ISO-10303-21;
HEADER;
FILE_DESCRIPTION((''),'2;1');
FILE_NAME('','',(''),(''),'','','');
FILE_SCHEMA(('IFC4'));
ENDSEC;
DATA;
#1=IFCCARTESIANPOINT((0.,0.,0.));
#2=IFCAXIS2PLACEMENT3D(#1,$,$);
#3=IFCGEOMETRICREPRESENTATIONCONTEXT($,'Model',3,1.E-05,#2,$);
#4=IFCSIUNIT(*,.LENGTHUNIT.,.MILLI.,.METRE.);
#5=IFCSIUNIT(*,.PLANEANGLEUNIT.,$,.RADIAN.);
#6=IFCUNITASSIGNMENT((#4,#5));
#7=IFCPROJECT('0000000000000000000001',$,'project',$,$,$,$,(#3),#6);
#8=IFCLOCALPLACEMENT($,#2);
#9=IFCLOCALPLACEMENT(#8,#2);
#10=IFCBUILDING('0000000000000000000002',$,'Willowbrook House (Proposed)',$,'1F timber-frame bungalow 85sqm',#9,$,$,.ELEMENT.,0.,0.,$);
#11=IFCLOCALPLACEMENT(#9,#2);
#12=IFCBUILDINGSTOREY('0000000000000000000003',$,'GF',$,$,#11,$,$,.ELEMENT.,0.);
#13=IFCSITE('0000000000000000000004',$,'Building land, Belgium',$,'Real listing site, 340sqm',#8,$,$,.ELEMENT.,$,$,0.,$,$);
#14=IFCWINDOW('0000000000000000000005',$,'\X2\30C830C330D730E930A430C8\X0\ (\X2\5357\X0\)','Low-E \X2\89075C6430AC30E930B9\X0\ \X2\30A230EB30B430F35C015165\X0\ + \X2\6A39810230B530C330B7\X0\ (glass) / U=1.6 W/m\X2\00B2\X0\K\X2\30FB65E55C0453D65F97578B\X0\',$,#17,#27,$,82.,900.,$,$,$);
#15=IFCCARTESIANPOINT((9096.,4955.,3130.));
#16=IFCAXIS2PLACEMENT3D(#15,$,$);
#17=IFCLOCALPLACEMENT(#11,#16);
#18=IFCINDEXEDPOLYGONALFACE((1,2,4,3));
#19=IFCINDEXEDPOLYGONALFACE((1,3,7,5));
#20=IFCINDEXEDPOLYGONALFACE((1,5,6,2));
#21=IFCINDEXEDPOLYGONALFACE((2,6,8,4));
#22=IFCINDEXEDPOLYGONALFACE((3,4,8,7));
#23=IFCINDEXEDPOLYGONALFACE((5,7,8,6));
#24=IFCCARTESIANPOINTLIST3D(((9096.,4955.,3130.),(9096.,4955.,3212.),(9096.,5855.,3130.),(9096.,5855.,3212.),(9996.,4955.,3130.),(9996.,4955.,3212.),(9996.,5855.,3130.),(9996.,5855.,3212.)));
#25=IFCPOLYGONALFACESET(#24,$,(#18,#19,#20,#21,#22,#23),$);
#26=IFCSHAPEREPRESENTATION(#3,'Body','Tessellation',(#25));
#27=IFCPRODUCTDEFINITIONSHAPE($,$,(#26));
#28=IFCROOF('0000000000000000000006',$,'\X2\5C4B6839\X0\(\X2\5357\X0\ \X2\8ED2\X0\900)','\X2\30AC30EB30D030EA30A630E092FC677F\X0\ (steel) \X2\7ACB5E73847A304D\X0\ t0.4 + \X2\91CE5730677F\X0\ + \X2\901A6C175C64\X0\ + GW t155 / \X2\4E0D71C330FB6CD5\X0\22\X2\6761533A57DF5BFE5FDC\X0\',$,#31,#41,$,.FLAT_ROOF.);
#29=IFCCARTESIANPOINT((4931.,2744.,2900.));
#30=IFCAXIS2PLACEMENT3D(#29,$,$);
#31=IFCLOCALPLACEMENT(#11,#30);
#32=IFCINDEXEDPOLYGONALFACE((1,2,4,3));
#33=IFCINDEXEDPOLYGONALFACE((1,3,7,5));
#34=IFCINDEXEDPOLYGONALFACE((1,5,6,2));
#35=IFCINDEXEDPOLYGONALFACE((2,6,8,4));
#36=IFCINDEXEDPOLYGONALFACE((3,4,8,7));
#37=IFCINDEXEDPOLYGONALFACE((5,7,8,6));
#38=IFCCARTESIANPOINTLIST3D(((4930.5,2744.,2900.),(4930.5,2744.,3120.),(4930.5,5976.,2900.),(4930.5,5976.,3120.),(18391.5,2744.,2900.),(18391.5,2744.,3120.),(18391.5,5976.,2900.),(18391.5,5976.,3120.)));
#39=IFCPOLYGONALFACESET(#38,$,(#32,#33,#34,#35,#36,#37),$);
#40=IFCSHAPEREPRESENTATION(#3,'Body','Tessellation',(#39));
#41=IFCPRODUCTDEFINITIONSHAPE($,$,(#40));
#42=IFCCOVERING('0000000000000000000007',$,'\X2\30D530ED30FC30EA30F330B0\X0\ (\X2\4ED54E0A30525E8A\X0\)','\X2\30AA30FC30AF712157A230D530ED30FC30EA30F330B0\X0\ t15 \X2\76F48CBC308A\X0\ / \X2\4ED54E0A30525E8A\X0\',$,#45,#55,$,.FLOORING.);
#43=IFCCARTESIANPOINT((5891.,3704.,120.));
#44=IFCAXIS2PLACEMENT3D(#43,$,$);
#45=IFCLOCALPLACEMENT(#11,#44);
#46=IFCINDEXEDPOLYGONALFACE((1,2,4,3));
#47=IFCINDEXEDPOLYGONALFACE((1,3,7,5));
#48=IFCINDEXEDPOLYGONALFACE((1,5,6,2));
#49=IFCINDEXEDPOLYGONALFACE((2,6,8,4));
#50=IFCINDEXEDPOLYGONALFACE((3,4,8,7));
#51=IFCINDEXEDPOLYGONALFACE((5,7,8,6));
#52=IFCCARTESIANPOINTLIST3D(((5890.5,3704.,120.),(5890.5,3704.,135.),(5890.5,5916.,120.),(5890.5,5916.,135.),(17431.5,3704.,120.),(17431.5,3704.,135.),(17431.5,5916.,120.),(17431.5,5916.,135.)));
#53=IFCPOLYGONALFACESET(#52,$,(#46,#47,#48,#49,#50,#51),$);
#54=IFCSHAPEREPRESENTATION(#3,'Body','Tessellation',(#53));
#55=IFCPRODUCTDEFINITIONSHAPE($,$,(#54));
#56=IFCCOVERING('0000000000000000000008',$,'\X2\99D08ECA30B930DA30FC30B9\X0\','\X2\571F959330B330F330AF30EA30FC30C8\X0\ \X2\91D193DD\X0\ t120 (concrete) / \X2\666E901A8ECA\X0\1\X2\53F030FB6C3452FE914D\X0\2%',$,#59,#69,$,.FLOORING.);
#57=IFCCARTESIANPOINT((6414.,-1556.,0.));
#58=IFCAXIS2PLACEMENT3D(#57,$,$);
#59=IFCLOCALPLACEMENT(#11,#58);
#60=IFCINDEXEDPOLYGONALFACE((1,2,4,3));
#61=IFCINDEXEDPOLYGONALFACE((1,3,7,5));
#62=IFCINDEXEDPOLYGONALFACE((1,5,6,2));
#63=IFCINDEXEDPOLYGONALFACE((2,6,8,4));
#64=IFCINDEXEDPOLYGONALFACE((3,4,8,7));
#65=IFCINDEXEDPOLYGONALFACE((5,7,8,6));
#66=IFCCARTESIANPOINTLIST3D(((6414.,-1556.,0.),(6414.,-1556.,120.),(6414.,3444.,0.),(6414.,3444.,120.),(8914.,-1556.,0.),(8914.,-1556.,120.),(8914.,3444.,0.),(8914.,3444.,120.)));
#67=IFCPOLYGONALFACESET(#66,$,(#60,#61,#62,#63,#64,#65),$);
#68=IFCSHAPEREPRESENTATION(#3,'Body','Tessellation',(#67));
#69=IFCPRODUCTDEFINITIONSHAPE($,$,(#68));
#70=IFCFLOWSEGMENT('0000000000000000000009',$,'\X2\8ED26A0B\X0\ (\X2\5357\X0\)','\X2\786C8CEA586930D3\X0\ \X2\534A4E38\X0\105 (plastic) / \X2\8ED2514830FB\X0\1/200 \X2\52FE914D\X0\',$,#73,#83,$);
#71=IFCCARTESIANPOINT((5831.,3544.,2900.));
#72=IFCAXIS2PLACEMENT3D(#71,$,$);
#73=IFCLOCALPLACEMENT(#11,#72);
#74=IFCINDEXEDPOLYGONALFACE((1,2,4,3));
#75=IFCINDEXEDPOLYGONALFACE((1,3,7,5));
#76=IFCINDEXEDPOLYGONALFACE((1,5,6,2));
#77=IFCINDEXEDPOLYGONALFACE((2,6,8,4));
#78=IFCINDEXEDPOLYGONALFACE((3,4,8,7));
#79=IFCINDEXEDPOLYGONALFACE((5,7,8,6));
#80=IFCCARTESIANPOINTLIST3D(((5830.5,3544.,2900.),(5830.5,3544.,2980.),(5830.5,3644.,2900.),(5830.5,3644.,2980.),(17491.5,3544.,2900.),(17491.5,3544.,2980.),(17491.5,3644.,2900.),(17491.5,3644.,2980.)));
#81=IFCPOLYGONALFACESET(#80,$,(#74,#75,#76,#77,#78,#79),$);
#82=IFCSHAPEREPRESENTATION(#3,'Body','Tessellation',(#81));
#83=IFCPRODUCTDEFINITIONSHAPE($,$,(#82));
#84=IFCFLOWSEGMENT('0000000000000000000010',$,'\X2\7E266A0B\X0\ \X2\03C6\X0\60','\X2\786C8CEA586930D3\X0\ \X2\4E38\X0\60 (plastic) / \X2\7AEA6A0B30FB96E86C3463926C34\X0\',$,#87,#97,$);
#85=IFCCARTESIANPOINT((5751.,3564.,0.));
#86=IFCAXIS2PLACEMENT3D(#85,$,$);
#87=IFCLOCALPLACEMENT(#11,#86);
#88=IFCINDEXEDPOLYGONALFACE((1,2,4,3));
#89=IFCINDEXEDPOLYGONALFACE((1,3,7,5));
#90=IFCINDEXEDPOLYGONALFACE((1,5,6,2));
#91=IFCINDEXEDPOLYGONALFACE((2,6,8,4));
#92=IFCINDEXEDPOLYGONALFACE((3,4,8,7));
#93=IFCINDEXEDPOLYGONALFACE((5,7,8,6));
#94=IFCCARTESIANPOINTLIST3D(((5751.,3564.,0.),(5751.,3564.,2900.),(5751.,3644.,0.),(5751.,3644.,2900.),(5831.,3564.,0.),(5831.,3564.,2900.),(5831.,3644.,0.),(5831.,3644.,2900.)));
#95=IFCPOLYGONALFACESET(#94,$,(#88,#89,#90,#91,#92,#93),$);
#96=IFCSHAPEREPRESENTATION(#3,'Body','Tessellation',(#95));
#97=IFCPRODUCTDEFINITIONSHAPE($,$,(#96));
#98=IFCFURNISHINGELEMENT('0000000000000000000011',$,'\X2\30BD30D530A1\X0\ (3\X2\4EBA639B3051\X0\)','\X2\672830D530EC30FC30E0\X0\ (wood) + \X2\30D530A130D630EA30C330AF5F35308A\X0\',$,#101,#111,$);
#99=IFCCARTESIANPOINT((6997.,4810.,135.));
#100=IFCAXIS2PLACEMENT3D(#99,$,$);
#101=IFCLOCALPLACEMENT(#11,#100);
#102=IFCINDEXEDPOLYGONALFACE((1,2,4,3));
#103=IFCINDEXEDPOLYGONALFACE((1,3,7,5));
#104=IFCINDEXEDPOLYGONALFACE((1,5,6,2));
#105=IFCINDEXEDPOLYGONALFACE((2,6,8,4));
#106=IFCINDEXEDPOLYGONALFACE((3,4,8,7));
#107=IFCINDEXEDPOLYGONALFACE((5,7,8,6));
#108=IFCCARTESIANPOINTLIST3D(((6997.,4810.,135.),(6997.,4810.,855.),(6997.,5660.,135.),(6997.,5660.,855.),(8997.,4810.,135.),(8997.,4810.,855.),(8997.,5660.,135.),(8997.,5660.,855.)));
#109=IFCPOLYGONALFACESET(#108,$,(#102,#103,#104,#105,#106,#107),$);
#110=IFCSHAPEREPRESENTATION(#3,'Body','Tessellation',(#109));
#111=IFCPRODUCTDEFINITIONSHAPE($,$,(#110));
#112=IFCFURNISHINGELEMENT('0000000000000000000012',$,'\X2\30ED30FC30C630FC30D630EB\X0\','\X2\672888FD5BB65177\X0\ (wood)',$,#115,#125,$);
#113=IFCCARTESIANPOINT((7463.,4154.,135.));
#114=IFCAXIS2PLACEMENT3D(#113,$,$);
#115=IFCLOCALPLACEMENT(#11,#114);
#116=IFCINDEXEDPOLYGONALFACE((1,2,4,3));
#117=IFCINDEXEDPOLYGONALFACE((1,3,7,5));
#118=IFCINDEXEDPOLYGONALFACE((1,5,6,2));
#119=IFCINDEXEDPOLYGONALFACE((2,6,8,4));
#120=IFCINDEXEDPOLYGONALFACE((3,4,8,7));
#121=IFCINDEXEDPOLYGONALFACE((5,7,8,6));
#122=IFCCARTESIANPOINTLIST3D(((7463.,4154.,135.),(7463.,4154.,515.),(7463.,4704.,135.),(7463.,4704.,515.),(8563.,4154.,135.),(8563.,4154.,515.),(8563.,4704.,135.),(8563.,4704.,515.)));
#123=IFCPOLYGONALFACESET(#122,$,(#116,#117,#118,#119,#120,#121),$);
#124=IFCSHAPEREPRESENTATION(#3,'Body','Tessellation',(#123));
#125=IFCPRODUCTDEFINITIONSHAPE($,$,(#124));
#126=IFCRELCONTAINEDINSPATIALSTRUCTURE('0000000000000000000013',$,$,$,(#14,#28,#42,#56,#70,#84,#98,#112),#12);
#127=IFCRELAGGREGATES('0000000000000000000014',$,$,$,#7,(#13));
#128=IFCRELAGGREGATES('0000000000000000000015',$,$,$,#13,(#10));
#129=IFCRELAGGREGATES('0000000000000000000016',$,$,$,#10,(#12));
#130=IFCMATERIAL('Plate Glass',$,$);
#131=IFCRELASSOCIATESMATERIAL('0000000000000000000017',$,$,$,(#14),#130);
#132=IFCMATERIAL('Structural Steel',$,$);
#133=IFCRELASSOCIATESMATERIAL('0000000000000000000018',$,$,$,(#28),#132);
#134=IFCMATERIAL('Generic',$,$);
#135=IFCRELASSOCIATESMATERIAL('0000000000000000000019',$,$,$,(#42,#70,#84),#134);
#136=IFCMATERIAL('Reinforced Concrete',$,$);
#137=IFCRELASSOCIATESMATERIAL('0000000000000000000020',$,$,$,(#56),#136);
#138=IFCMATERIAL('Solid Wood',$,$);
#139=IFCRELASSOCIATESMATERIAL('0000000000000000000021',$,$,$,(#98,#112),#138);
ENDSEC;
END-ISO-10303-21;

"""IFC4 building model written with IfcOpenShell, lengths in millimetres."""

from ifc_helpers import new_model, si_unit, frame, frame_2d, origin, place, context, project, spatial, rectangle, extrude, material, element, save


model = new_model("IFC4")

# Units and contexts
model_context = context("Model", 3, precision=1e-05, world=origin())
ifc_project = project(units=[si_unit("LENGTHUNIT", "METRE", prefix="MILLI"), si_unit("PLANEANGLEUNIT", "RADIAN")], contexts=[model_context])

# Site, building, storey
site_placement = place(None, origin())
site = spatial("IfcSite", under=ifc_project, at=site_placement, Name="Building land, Belgium", ObjectType="Real listing site, 340sqm", CompositionType="ELEMENT", RefElevation=0.0)
building_placement = place(site_placement, origin())
building = spatial("IfcBuilding", under=site, at=building_placement, Name="Willowbrook House (Proposed)", ObjectType="1F timber-frame bungalow 85sqm", CompositionType="ELEMENT", ElevationOfRefHeight=0.0, ElevationOfTerrain=0.0)
storey_placement = place(building_placement, origin())
storey = spatial("IfcBuildingStorey", under=building, at=storey_placement, Name="GF", CompositionType="ELEMENT", Elevation=0.0)

# Shared definitions
ifc_material_1 = material(Name="Solid Wood")

# Shared definitions
ifc_material_2 = material(Name="Reinforced Concrete")

# Shared definitions
ifc_material_3 = material(Name="Plate Glass")

# Window
window_1_placement = place(storey_placement, frame((9096.0, 4955.0, 3130.0)))
element("IfcWindow", 1, at=window_1_placement, inside=storey, material=ifc_material_3, Name="トップライト (南)", Description="Low-E 複層ガラス アルゴン封入 + 樹脂サッシ (glass) / U=1.6 W/m²K・日射取得型", OverallHeight=82.0, OverallWidth=900.0, context=model_context, shape_type="SweptSolid", body=[
    extrude(rectangle(XDim=900.0, YDim=900.0, at=frame_2d((450.0, 450.0))), frame((9096.0, 4955.0, 3130.0)), (0.0, 0.0, 1.0), 82.0),
])

# Roof
ifc_material_4 = material(Name="Structural Steel")
roof_1_placement = place(storey_placement, frame((4931.0, 2744.0, 2900.0)))
element("IfcRoof", 2, at=roof_1_placement, inside=storey, material=ifc_material_4, Name="屋根(南 軒900)", Description="ガルバリウム鋼板 (steel) 立平葺き t0.4 + 野地板 + 通気層 + GW t155 / 不燃・法22条区域対応", PredefinedType="FLAT_ROOF", context=model_context, shape_type="SweptSolid", body=[
    extrude(rectangle(XDim=13461.0, YDim=3232.0, at=frame_2d((6730.0, 1616.0))), frame((4931.0, 2744.0, 2900.0)), (0.0, 0.0, 1.0), 220.0),
])

# Coverings
ifc_material_5 = material(Name="Generic")
covering_1_placement = place(storey_placement, frame((5891.0, 3704.0, 120.0)))
element("IfcCovering", 3, at=covering_1_placement, inside=storey, material=ifc_material_5, Name="フローリング (仕上げ床)", Description="オーク無垢フローリング t15 直貼り / 仕上げ床", PredefinedType="FLOORING", context=model_context, shape_type="SweptSolid", body=[
    extrude(rectangle(XDim=11541.0, YDim=2212.0, at=frame_2d((5770.0, 1106.0))), frame((5891.0, 3704.0, 120.0)), (0.0, 0.0, 1.0), 15.0),
])
covering_2_placement = place(storey_placement, frame((6414.0, -1556.0, 0.0)))
element("IfcCovering", 4, at=covering_2_placement, inside=storey, material=ifc_material_2, Name="駐車スペース", Description="土間コンクリート 金鏝 t120 (concrete) / 普通車1台・水勾配2%", PredefinedType="FLOORING", context=model_context, shape_type="SweptSolid", body=[
    extrude(rectangle(XDim=2500.0, YDim=5000.0, at=frame_2d((1250.0, 2500.0))), frame((6414.0, -1556.0, 0.0)), (0.0, 0.0, 1.0), 120.0),
])

# Flow segments
flow_segment_1_placement = place(storey_placement, frame((5831.0, 3544.0, 2900.0)))
element("IfcFlowSegment", 5, at=flow_segment_1_placement, inside=storey, material=ifc_material_5, Name="軒樋 (南)", Description="硬質塩ビ 半丸105 (plastic) / 軒先・1/200 勾配", context=model_context, shape_type="SweptSolid", body=[
    extrude(rectangle(XDim=11661.0, YDim=100.0, at=frame_2d((5830.0, 50.0))), frame((5831.0, 3544.0, 2900.0)), (0.0, 0.0, 1.0), 80.0),
])
flow_segment_2_placement = place(storey_placement, frame((5751.0, 3564.0, 0.0)))
element("IfcFlowSegment", 6, at=flow_segment_2_placement, inside=storey, material=ifc_material_5, Name="縦樋 φ60", Description="硬質塩ビ 丸60 (plastic) / 竪樋・雨水排水", context=model_context, shape_type="SweptSolid", body=[
    extrude(rectangle(XDim=80.0, YDim=80.0, at=frame_2d((40.0, 40.0))), frame((5751.0, 3564.0, 0.0)), (0.0, 0.0, 1.0), 2900.0),
])

# Furnishing elements
furnishing_1_placement = place(storey_placement, frame((6997.0, 4810.0, 135.0)))
element("IfcFurnishingElement", 7, at=furnishing_1_placement, inside=storey, material=ifc_material_1, Name="ソファ (3人掛け)", Description="木フレーム (wood) + ファブリック張り", context=model_context, shape_type="SweptSolid", body=[
    extrude(rectangle(XDim=2000.0, YDim=850.0, at=frame_2d((1000.0, 425.0))), frame((6997.0, 4810.0, 135.0)), (0.0, 0.0, 1.0), 720.0),
])
furnishing_2_placement = place(storey_placement, frame((7463.0, 4154.0, 135.0)))
element("IfcFurnishingElement", 8, at=furnishing_2_placement, inside=storey, material=ifc_material_1, Name="ローテーブル", Description="木製家具 (wood)", context=model_context, shape_type="SweptSolid", body=[
    extrude(rectangle(XDim=1100.0, YDim=550.0, at=frame_2d((550.0, 275.0))), frame((7463.0, 4154.0, 135.0)), (0.0, 0.0, 1.0), 380.0),
])

save(model, "model.ifc")
